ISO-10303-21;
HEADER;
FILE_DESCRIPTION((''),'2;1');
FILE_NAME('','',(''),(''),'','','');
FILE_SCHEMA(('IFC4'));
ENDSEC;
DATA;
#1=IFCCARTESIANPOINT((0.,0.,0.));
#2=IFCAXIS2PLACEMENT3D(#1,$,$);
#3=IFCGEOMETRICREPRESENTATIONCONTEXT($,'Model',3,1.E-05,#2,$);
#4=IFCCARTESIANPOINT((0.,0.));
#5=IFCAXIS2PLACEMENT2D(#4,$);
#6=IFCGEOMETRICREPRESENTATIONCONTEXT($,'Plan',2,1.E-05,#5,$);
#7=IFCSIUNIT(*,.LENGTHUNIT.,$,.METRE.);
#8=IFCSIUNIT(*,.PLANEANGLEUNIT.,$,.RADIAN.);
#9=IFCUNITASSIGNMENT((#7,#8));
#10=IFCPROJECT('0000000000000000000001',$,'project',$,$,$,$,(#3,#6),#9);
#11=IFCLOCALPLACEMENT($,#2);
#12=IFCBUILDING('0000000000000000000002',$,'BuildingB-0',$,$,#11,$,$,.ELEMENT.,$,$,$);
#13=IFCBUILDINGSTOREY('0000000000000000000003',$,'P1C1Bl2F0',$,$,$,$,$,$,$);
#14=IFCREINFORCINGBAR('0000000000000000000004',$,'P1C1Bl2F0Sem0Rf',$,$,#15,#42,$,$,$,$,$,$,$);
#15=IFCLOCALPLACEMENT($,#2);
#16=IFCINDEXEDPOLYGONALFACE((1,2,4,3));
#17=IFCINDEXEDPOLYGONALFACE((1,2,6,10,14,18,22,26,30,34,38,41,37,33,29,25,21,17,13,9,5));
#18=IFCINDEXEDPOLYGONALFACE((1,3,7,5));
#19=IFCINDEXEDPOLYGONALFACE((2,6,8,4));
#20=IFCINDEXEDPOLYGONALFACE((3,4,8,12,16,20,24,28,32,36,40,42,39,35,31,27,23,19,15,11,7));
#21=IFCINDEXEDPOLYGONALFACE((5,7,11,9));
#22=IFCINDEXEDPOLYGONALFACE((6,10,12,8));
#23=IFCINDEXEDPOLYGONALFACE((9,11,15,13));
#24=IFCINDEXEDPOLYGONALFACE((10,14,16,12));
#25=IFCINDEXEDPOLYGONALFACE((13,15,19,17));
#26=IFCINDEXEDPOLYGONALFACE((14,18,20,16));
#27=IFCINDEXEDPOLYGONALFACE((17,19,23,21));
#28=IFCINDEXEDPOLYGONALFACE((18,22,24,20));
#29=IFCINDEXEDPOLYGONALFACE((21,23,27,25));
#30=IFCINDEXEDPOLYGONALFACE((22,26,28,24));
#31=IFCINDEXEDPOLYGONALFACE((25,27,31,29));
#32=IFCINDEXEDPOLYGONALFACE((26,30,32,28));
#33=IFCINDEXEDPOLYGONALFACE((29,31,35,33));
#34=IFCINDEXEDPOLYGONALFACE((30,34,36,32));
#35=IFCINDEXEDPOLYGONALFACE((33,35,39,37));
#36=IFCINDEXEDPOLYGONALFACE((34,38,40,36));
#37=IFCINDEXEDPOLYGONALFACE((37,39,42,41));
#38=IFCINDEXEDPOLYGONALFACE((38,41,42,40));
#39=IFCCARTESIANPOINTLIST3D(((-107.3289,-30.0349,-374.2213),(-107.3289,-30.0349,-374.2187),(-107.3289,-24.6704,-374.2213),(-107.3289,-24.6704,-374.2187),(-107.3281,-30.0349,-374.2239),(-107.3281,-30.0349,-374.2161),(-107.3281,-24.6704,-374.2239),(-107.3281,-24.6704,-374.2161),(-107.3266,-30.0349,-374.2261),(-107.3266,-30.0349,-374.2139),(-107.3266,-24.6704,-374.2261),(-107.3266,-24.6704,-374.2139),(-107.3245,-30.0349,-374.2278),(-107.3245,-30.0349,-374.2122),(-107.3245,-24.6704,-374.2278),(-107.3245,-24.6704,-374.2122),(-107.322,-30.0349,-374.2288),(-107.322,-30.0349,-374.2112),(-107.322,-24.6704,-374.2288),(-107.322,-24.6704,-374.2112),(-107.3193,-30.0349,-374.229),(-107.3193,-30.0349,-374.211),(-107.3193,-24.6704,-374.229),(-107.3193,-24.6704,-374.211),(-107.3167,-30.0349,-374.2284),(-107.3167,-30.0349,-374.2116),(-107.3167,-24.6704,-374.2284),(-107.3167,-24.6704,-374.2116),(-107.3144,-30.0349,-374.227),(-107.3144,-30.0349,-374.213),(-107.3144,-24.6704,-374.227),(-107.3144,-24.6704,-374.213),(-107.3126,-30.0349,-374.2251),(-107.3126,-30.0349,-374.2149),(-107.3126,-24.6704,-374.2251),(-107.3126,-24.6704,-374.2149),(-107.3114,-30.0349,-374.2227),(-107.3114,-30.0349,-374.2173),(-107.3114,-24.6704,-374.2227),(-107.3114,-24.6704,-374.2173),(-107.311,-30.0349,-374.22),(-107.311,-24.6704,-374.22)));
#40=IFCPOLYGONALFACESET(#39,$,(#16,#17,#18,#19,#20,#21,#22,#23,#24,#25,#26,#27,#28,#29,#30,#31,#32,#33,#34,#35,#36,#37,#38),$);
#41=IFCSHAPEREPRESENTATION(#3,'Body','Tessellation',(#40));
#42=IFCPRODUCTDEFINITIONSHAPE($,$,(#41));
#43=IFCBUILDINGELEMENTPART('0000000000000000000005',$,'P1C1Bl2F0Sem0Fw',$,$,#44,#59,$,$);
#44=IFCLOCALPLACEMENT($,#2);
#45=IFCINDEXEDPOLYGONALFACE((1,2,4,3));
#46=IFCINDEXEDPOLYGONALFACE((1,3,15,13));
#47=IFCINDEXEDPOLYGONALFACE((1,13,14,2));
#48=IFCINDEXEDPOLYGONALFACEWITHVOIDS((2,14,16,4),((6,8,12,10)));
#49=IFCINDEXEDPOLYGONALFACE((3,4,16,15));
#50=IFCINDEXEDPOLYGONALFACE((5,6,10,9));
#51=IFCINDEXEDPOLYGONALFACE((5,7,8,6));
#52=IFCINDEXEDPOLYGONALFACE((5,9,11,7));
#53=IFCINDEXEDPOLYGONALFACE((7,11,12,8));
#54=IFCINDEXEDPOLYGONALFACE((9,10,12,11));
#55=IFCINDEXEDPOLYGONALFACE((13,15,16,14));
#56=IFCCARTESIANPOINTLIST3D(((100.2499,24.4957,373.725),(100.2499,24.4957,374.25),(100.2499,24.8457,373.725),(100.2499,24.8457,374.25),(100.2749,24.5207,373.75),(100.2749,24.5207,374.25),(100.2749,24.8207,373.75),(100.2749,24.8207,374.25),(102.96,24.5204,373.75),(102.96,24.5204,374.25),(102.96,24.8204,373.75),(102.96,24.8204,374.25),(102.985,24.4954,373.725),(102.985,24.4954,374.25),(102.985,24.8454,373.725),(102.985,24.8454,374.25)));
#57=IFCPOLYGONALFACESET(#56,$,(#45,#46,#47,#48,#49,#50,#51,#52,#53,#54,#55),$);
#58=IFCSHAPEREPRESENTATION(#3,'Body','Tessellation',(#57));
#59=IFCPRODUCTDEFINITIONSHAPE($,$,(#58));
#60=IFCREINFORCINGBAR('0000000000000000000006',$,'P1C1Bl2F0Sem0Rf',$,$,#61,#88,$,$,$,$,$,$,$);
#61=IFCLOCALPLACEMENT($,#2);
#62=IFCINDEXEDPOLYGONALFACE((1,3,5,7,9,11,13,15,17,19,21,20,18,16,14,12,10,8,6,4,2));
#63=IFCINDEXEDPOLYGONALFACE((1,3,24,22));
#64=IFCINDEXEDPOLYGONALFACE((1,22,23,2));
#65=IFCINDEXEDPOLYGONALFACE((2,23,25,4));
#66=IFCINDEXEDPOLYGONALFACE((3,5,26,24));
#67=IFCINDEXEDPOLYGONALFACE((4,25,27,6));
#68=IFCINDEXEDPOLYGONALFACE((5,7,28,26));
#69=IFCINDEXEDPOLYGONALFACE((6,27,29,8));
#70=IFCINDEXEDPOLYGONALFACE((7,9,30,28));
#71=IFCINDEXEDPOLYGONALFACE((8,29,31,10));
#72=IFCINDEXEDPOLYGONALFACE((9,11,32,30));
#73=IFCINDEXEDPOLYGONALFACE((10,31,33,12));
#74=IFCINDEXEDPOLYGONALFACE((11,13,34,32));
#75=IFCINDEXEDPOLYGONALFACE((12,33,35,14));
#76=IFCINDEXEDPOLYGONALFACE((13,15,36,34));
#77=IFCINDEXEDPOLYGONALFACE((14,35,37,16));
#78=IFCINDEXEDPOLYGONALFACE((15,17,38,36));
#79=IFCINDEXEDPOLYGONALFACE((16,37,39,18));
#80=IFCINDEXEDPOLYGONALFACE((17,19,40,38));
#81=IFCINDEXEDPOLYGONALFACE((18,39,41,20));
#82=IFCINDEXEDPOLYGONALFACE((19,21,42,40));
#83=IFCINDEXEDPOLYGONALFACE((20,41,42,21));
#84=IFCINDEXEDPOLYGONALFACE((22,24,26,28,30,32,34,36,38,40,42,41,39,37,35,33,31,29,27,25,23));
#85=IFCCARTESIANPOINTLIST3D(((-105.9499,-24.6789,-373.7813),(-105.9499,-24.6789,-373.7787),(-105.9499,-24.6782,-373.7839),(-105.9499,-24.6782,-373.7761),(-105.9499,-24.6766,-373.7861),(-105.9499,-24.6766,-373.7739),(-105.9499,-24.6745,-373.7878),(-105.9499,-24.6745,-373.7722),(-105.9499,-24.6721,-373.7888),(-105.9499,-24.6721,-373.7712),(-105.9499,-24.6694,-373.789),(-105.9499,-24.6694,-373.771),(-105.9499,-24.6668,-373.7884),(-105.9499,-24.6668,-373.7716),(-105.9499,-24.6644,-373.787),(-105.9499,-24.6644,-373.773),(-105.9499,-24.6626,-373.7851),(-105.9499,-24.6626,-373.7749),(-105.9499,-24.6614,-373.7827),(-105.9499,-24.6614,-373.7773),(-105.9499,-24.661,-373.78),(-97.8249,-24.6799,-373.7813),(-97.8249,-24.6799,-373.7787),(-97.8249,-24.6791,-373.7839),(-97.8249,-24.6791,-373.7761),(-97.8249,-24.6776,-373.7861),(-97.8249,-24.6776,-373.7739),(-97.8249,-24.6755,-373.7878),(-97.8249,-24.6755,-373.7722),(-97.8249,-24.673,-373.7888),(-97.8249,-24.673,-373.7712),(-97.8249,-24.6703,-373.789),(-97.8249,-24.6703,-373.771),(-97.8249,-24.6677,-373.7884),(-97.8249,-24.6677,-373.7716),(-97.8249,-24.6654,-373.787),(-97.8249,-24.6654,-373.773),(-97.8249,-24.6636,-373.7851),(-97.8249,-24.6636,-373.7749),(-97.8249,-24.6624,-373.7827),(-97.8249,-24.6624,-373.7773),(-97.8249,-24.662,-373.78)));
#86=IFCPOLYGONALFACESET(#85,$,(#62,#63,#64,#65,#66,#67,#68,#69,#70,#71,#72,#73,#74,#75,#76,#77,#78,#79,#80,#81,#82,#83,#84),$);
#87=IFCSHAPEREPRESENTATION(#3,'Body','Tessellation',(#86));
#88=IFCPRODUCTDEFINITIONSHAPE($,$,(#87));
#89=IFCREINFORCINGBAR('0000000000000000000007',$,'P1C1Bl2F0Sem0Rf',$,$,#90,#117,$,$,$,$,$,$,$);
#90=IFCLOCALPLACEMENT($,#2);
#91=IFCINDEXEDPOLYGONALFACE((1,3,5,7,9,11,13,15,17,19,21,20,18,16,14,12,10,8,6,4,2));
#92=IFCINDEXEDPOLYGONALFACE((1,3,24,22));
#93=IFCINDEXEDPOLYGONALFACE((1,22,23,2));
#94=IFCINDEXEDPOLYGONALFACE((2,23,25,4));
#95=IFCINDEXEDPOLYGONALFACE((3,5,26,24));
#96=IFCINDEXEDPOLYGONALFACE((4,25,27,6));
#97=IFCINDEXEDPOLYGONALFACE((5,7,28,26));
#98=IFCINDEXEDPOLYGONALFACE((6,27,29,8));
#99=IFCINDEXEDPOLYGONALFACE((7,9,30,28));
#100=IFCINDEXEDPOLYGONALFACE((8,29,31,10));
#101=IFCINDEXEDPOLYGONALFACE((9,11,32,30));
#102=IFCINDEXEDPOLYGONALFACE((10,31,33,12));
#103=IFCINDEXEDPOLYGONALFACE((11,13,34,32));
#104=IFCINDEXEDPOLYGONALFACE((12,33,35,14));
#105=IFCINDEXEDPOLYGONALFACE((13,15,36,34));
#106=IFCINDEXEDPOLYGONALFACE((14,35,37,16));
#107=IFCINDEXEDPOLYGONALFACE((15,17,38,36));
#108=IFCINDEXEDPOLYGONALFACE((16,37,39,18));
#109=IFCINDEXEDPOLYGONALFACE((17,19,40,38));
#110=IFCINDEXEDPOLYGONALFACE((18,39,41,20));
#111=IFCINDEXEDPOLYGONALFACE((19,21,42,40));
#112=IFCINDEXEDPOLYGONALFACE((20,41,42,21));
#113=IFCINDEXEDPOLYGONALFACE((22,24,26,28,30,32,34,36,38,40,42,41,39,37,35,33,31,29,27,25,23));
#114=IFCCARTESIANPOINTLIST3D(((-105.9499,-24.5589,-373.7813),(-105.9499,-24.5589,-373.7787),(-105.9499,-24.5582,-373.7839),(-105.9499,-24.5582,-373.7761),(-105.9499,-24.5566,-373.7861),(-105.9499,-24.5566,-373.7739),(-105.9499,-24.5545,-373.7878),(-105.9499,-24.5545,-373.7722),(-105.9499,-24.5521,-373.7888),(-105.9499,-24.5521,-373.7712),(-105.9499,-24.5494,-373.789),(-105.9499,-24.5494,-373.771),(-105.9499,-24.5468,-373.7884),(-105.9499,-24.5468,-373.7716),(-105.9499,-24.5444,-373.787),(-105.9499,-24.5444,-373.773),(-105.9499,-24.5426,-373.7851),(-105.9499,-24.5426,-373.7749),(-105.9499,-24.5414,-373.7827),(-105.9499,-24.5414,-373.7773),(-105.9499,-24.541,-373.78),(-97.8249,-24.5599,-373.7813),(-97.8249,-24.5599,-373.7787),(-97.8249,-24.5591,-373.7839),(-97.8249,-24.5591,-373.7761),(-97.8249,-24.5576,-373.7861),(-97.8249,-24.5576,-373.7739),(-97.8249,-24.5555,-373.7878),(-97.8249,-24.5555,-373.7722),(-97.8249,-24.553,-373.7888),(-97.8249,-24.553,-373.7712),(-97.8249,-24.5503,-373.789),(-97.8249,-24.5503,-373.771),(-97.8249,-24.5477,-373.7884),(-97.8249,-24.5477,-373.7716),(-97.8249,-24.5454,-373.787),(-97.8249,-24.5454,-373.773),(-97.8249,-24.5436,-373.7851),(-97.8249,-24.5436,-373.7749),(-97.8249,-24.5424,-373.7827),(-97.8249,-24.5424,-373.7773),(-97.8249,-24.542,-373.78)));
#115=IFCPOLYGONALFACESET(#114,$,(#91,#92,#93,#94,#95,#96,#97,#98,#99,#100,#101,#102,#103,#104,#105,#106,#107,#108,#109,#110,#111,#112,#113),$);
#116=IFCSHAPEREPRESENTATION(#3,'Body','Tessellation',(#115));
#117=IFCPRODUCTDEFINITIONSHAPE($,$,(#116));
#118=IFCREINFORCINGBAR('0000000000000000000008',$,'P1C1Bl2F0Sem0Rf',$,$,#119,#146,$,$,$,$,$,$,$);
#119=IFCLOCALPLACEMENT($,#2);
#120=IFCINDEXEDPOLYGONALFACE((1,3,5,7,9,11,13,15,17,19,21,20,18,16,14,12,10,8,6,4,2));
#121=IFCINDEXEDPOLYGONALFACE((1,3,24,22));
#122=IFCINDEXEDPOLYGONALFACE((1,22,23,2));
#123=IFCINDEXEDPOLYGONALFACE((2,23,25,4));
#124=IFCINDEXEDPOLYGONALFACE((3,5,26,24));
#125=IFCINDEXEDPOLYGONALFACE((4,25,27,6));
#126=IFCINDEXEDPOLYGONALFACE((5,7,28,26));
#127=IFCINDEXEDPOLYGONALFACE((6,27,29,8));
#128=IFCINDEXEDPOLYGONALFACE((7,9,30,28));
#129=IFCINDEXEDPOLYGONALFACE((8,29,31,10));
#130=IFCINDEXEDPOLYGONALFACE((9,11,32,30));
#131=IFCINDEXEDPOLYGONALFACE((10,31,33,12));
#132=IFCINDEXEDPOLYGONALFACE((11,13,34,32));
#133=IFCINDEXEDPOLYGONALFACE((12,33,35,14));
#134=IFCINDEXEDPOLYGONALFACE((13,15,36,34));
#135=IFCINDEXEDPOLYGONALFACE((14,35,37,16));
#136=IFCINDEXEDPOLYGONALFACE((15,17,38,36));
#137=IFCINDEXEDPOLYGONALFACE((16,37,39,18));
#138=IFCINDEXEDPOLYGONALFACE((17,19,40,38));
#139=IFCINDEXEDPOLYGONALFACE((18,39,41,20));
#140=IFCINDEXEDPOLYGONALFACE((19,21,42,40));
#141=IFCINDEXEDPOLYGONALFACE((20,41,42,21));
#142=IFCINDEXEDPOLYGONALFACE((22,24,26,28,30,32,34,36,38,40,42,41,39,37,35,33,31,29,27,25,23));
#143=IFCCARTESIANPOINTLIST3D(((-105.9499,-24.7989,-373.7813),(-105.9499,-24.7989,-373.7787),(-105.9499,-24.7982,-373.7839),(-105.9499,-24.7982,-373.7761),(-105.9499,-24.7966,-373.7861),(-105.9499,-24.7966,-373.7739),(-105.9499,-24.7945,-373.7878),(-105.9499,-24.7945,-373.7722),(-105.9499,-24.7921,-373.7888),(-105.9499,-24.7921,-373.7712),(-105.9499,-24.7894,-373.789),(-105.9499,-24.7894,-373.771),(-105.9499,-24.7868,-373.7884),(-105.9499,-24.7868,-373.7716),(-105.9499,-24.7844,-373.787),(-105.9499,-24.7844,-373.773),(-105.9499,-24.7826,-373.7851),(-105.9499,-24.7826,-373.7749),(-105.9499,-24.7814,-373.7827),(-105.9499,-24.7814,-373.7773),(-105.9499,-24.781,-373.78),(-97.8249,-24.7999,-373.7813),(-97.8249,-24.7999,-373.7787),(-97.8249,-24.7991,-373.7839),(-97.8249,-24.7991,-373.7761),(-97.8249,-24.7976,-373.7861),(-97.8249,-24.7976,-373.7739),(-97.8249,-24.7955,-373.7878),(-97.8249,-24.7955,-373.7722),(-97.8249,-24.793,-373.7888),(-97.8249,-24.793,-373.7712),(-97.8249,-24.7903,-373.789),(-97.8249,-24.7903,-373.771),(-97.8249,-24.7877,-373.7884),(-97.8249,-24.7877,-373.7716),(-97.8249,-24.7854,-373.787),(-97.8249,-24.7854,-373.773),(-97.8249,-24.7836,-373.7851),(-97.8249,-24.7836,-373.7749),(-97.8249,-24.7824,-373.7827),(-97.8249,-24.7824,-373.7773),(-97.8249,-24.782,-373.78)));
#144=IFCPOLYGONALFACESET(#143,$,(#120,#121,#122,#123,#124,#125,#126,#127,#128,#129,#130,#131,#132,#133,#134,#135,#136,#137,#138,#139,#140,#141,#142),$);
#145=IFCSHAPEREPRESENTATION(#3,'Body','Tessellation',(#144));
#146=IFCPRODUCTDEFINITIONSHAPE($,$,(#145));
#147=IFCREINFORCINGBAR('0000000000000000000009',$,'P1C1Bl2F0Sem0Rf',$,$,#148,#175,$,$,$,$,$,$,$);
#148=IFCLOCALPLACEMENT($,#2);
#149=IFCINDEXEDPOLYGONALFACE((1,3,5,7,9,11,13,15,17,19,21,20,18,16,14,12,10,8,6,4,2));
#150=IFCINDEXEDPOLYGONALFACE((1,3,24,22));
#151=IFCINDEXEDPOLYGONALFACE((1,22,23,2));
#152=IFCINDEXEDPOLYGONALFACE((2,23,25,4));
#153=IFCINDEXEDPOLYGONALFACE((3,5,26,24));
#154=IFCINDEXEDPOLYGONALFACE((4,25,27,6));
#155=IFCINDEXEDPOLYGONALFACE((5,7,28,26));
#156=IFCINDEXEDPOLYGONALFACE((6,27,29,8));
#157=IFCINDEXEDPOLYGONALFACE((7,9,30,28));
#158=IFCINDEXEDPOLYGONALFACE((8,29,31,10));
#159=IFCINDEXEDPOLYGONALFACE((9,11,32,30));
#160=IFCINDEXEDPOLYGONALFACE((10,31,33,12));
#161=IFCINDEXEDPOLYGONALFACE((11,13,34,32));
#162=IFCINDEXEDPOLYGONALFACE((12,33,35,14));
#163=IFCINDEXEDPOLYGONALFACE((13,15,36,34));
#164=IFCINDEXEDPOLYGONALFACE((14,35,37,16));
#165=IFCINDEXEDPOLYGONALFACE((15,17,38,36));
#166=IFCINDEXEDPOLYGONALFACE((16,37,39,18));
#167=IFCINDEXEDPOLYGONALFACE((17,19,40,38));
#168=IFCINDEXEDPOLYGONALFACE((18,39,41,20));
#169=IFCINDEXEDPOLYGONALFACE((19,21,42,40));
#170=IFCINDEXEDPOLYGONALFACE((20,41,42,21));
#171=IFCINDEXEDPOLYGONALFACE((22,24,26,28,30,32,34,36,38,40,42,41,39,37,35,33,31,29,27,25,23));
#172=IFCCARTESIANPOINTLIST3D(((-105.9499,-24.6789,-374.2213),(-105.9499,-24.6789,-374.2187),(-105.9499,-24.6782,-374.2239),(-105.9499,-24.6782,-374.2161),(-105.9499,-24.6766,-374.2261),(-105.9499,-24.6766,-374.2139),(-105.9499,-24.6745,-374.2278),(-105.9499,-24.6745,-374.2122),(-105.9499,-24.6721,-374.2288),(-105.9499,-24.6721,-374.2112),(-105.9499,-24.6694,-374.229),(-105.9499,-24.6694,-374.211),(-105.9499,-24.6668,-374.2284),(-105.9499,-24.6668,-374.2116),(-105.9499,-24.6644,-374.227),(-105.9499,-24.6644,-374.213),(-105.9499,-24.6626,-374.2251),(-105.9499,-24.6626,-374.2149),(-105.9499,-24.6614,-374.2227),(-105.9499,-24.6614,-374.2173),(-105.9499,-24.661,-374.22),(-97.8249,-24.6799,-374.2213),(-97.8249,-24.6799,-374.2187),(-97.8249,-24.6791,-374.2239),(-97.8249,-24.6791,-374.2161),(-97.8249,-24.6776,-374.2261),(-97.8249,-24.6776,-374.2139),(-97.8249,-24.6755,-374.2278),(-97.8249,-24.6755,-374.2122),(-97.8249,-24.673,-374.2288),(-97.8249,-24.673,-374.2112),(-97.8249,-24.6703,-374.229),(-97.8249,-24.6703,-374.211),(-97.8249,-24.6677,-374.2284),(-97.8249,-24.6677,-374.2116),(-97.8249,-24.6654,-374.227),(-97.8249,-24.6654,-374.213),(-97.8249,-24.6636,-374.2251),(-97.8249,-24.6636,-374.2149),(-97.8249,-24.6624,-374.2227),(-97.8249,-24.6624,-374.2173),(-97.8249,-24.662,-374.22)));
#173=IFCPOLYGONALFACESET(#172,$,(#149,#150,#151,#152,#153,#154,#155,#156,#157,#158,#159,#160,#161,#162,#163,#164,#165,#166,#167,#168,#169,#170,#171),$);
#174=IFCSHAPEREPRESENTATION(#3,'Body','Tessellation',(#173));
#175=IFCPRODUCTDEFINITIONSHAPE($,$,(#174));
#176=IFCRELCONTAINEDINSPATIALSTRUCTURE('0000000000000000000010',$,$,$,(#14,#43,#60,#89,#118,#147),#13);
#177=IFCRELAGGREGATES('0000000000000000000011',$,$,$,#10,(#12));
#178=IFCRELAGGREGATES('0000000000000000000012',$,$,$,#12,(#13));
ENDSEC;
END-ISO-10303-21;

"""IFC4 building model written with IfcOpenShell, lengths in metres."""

from ifc_helpers import new_model, entity, si_unit, origin, origin_2d, place, context, project, spatial, polyline, outline, extrude, element, save


model = new_model("IFC4")

# Units and contexts
model_context = context("Model", 3, precision=1e-05, world=origin())
plan_context = context("Plan", 2, precision=1e-05, world=origin_2d())
ifc_project = project(units=[si_unit("LENGTHUNIT", "METRE"), si_unit("PLANEANGLEUNIT", "RADIAN")], contexts=[model_context, plan_context])

# Building, storey
building_placement = place(None, origin())
building = spatial("IfcBuilding", under=ifc_project, at=building_placement, Name="BuildingB-0", CompositionType="ELEMENT")
storey = spatial("IfcBuildingStorey", under=building, Name="P1C1Bl2F0")

# Reinforcing bar
element("IfcReinforcingBar", 1, inside=storey, Name="P1C1Bl2F0Sem0Rf", context=model_context, shape_type="SweptSolid", body=[
    entity("IfcSurfaceCurveSweptAreaSolid", entity("IfcCircleProfileDef", "AREA", None, None, 0.009), None, entity("IfcPolyline", [entity("IfcCartesianPoint", [107.32, 24.6704, 374.22]), entity("IfcCartesianPoint", [107.32, 30.0349, 374.22])]), None, None, entity("IfcPlane", entity("IfcAxis2Placement3D", entity("IfcCartesianPoint", [107.32, 24.6704, 374.22]), entity("IfcDirection", [0.0, 0.0, 1.0]), entity("IfcDirection", [1.0, 0.0, 0.0])))),
])

# Building element part, opening
building_element_part_1 = element("IfcBuildingElementPart", 2, inside=storey, Name="P1C1Bl2F0Sem0Fw", context=model_context, shape_type="SweptSolid", body=[
    extrude(outline(polyline([(102.985, 24.4954, 373.725), (102.985, 24.8454, 373.725), (100.2499, 24.8457, 373.725), (100.2499, 24.4957, 373.725), (102.985, 24.4954, 373.725)])), None, (0.0, 0.0, 1.0), 0.525),
])
element("IfcOpeningElement", 3, inside=storey, cuts=building_element_part_1, context=model_context, shape_type="SweptSolid", body=[
    extrude(outline(polyline([(102.96, 24.5204, 373.75), (102.96, 24.8204, 373.75), (100.2749, 24.8207, 373.75), (100.2749, 24.5207, 373.75), (102.96, 24.5204, 373.75)])), None, (0.0, 0.0, 1.0), 0.5),
])

# Reinforcing bars
element("IfcReinforcingBar", 4, inside=storey, Name="P1C1Bl2F0Sem0Rf", context=model_context, shape_type="SweptSolid", body=[
    entity("IfcSurfaceCurveSweptAreaSolid", entity("IfcCircleProfileDef", "AREA", None, None, 0.009), None, entity("IfcPolyline", [entity("IfcCartesianPoint", [97.8249, 24.671, 373.78]), entity("IfcCartesianPoint", [105.9499, 24.67, 373.78])]), None, None, entity("IfcPlane", entity("IfcAxis2Placement3D", entity("IfcCartesianPoint", [97.8249, 24.671, 373.78]), entity("IfcDirection", [0.0, 0.0, 1.0]), entity("IfcDirection", [1.0, 0.0, 0.0])))),
])
element("IfcReinforcingBar", 5, inside=storey, Name="P1C1Bl2F0Sem0Rf", context=model_context, shape_type="SweptSolid", body=[
    entity("IfcSurfaceCurveSweptAreaSolid", entity("IfcCircleProfileDef", "AREA", None, None, 0.009), None, entity("IfcPolyline", [entity("IfcCartesianPoint", [97.8249, 24.551, 373.78]), entity("IfcCartesianPoint", [105.9499, 24.55, 373.78])]), None, None, entity("IfcPlane", entity("IfcAxis2Placement3D", entity("IfcCartesianPoint", [97.8249, 24.551, 373.78]), entity("IfcDirection", [0.0, 0.0, 1.0]), entity("IfcDirection", [1.0, 0.0, 0.0])))),
])
element("IfcReinforcingBar", 6, inside=storey, Name="P1C1Bl2F0Sem0Rf", context=model_context, shape_type="SweptSolid", body=[
    entity("IfcSurfaceCurveSweptAreaSolid", entity("IfcCircleProfileDef", "AREA", None, None, 0.009), None, entity("IfcPolyline", [entity("IfcCartesianPoint", [97.8249, 24.791, 373.78]), entity("IfcCartesianPoint", [105.9499, 24.79, 373.78])]), None, None, entity("IfcPlane", entity("IfcAxis2Placement3D", entity("IfcCartesianPoint", [97.8249, 24.791, 373.78]), entity("IfcDirection", [0.0, 0.0, 1.0]), entity("IfcDirection", [1.0, 0.0, 0.0])))),
])
element("IfcReinforcingBar", 7, inside=storey, Name="P1C1Bl2F0Sem0Rf", context=model_context, shape_type="SweptSolid", body=[
    entity("IfcSurfaceCurveSweptAreaSolid", entity("IfcCircleProfileDef", "AREA", None, None, 0.009), None, entity("IfcPolyline", [entity("IfcCartesianPoint", [97.8249, 24.671, 374.22]), entity("IfcCartesianPoint", [105.9499, 24.67, 374.22])]), None, None, entity("IfcPlane", entity("IfcAxis2Placement3D", entity("IfcCartesianPoint", [97.8249, 24.671, 374.22]), entity("IfcDirection", [0.0, 0.0, 1.0]), entity("IfcDirection", [1.0, 0.0, 0.0])))),
])

save(model, "model.ifc")
